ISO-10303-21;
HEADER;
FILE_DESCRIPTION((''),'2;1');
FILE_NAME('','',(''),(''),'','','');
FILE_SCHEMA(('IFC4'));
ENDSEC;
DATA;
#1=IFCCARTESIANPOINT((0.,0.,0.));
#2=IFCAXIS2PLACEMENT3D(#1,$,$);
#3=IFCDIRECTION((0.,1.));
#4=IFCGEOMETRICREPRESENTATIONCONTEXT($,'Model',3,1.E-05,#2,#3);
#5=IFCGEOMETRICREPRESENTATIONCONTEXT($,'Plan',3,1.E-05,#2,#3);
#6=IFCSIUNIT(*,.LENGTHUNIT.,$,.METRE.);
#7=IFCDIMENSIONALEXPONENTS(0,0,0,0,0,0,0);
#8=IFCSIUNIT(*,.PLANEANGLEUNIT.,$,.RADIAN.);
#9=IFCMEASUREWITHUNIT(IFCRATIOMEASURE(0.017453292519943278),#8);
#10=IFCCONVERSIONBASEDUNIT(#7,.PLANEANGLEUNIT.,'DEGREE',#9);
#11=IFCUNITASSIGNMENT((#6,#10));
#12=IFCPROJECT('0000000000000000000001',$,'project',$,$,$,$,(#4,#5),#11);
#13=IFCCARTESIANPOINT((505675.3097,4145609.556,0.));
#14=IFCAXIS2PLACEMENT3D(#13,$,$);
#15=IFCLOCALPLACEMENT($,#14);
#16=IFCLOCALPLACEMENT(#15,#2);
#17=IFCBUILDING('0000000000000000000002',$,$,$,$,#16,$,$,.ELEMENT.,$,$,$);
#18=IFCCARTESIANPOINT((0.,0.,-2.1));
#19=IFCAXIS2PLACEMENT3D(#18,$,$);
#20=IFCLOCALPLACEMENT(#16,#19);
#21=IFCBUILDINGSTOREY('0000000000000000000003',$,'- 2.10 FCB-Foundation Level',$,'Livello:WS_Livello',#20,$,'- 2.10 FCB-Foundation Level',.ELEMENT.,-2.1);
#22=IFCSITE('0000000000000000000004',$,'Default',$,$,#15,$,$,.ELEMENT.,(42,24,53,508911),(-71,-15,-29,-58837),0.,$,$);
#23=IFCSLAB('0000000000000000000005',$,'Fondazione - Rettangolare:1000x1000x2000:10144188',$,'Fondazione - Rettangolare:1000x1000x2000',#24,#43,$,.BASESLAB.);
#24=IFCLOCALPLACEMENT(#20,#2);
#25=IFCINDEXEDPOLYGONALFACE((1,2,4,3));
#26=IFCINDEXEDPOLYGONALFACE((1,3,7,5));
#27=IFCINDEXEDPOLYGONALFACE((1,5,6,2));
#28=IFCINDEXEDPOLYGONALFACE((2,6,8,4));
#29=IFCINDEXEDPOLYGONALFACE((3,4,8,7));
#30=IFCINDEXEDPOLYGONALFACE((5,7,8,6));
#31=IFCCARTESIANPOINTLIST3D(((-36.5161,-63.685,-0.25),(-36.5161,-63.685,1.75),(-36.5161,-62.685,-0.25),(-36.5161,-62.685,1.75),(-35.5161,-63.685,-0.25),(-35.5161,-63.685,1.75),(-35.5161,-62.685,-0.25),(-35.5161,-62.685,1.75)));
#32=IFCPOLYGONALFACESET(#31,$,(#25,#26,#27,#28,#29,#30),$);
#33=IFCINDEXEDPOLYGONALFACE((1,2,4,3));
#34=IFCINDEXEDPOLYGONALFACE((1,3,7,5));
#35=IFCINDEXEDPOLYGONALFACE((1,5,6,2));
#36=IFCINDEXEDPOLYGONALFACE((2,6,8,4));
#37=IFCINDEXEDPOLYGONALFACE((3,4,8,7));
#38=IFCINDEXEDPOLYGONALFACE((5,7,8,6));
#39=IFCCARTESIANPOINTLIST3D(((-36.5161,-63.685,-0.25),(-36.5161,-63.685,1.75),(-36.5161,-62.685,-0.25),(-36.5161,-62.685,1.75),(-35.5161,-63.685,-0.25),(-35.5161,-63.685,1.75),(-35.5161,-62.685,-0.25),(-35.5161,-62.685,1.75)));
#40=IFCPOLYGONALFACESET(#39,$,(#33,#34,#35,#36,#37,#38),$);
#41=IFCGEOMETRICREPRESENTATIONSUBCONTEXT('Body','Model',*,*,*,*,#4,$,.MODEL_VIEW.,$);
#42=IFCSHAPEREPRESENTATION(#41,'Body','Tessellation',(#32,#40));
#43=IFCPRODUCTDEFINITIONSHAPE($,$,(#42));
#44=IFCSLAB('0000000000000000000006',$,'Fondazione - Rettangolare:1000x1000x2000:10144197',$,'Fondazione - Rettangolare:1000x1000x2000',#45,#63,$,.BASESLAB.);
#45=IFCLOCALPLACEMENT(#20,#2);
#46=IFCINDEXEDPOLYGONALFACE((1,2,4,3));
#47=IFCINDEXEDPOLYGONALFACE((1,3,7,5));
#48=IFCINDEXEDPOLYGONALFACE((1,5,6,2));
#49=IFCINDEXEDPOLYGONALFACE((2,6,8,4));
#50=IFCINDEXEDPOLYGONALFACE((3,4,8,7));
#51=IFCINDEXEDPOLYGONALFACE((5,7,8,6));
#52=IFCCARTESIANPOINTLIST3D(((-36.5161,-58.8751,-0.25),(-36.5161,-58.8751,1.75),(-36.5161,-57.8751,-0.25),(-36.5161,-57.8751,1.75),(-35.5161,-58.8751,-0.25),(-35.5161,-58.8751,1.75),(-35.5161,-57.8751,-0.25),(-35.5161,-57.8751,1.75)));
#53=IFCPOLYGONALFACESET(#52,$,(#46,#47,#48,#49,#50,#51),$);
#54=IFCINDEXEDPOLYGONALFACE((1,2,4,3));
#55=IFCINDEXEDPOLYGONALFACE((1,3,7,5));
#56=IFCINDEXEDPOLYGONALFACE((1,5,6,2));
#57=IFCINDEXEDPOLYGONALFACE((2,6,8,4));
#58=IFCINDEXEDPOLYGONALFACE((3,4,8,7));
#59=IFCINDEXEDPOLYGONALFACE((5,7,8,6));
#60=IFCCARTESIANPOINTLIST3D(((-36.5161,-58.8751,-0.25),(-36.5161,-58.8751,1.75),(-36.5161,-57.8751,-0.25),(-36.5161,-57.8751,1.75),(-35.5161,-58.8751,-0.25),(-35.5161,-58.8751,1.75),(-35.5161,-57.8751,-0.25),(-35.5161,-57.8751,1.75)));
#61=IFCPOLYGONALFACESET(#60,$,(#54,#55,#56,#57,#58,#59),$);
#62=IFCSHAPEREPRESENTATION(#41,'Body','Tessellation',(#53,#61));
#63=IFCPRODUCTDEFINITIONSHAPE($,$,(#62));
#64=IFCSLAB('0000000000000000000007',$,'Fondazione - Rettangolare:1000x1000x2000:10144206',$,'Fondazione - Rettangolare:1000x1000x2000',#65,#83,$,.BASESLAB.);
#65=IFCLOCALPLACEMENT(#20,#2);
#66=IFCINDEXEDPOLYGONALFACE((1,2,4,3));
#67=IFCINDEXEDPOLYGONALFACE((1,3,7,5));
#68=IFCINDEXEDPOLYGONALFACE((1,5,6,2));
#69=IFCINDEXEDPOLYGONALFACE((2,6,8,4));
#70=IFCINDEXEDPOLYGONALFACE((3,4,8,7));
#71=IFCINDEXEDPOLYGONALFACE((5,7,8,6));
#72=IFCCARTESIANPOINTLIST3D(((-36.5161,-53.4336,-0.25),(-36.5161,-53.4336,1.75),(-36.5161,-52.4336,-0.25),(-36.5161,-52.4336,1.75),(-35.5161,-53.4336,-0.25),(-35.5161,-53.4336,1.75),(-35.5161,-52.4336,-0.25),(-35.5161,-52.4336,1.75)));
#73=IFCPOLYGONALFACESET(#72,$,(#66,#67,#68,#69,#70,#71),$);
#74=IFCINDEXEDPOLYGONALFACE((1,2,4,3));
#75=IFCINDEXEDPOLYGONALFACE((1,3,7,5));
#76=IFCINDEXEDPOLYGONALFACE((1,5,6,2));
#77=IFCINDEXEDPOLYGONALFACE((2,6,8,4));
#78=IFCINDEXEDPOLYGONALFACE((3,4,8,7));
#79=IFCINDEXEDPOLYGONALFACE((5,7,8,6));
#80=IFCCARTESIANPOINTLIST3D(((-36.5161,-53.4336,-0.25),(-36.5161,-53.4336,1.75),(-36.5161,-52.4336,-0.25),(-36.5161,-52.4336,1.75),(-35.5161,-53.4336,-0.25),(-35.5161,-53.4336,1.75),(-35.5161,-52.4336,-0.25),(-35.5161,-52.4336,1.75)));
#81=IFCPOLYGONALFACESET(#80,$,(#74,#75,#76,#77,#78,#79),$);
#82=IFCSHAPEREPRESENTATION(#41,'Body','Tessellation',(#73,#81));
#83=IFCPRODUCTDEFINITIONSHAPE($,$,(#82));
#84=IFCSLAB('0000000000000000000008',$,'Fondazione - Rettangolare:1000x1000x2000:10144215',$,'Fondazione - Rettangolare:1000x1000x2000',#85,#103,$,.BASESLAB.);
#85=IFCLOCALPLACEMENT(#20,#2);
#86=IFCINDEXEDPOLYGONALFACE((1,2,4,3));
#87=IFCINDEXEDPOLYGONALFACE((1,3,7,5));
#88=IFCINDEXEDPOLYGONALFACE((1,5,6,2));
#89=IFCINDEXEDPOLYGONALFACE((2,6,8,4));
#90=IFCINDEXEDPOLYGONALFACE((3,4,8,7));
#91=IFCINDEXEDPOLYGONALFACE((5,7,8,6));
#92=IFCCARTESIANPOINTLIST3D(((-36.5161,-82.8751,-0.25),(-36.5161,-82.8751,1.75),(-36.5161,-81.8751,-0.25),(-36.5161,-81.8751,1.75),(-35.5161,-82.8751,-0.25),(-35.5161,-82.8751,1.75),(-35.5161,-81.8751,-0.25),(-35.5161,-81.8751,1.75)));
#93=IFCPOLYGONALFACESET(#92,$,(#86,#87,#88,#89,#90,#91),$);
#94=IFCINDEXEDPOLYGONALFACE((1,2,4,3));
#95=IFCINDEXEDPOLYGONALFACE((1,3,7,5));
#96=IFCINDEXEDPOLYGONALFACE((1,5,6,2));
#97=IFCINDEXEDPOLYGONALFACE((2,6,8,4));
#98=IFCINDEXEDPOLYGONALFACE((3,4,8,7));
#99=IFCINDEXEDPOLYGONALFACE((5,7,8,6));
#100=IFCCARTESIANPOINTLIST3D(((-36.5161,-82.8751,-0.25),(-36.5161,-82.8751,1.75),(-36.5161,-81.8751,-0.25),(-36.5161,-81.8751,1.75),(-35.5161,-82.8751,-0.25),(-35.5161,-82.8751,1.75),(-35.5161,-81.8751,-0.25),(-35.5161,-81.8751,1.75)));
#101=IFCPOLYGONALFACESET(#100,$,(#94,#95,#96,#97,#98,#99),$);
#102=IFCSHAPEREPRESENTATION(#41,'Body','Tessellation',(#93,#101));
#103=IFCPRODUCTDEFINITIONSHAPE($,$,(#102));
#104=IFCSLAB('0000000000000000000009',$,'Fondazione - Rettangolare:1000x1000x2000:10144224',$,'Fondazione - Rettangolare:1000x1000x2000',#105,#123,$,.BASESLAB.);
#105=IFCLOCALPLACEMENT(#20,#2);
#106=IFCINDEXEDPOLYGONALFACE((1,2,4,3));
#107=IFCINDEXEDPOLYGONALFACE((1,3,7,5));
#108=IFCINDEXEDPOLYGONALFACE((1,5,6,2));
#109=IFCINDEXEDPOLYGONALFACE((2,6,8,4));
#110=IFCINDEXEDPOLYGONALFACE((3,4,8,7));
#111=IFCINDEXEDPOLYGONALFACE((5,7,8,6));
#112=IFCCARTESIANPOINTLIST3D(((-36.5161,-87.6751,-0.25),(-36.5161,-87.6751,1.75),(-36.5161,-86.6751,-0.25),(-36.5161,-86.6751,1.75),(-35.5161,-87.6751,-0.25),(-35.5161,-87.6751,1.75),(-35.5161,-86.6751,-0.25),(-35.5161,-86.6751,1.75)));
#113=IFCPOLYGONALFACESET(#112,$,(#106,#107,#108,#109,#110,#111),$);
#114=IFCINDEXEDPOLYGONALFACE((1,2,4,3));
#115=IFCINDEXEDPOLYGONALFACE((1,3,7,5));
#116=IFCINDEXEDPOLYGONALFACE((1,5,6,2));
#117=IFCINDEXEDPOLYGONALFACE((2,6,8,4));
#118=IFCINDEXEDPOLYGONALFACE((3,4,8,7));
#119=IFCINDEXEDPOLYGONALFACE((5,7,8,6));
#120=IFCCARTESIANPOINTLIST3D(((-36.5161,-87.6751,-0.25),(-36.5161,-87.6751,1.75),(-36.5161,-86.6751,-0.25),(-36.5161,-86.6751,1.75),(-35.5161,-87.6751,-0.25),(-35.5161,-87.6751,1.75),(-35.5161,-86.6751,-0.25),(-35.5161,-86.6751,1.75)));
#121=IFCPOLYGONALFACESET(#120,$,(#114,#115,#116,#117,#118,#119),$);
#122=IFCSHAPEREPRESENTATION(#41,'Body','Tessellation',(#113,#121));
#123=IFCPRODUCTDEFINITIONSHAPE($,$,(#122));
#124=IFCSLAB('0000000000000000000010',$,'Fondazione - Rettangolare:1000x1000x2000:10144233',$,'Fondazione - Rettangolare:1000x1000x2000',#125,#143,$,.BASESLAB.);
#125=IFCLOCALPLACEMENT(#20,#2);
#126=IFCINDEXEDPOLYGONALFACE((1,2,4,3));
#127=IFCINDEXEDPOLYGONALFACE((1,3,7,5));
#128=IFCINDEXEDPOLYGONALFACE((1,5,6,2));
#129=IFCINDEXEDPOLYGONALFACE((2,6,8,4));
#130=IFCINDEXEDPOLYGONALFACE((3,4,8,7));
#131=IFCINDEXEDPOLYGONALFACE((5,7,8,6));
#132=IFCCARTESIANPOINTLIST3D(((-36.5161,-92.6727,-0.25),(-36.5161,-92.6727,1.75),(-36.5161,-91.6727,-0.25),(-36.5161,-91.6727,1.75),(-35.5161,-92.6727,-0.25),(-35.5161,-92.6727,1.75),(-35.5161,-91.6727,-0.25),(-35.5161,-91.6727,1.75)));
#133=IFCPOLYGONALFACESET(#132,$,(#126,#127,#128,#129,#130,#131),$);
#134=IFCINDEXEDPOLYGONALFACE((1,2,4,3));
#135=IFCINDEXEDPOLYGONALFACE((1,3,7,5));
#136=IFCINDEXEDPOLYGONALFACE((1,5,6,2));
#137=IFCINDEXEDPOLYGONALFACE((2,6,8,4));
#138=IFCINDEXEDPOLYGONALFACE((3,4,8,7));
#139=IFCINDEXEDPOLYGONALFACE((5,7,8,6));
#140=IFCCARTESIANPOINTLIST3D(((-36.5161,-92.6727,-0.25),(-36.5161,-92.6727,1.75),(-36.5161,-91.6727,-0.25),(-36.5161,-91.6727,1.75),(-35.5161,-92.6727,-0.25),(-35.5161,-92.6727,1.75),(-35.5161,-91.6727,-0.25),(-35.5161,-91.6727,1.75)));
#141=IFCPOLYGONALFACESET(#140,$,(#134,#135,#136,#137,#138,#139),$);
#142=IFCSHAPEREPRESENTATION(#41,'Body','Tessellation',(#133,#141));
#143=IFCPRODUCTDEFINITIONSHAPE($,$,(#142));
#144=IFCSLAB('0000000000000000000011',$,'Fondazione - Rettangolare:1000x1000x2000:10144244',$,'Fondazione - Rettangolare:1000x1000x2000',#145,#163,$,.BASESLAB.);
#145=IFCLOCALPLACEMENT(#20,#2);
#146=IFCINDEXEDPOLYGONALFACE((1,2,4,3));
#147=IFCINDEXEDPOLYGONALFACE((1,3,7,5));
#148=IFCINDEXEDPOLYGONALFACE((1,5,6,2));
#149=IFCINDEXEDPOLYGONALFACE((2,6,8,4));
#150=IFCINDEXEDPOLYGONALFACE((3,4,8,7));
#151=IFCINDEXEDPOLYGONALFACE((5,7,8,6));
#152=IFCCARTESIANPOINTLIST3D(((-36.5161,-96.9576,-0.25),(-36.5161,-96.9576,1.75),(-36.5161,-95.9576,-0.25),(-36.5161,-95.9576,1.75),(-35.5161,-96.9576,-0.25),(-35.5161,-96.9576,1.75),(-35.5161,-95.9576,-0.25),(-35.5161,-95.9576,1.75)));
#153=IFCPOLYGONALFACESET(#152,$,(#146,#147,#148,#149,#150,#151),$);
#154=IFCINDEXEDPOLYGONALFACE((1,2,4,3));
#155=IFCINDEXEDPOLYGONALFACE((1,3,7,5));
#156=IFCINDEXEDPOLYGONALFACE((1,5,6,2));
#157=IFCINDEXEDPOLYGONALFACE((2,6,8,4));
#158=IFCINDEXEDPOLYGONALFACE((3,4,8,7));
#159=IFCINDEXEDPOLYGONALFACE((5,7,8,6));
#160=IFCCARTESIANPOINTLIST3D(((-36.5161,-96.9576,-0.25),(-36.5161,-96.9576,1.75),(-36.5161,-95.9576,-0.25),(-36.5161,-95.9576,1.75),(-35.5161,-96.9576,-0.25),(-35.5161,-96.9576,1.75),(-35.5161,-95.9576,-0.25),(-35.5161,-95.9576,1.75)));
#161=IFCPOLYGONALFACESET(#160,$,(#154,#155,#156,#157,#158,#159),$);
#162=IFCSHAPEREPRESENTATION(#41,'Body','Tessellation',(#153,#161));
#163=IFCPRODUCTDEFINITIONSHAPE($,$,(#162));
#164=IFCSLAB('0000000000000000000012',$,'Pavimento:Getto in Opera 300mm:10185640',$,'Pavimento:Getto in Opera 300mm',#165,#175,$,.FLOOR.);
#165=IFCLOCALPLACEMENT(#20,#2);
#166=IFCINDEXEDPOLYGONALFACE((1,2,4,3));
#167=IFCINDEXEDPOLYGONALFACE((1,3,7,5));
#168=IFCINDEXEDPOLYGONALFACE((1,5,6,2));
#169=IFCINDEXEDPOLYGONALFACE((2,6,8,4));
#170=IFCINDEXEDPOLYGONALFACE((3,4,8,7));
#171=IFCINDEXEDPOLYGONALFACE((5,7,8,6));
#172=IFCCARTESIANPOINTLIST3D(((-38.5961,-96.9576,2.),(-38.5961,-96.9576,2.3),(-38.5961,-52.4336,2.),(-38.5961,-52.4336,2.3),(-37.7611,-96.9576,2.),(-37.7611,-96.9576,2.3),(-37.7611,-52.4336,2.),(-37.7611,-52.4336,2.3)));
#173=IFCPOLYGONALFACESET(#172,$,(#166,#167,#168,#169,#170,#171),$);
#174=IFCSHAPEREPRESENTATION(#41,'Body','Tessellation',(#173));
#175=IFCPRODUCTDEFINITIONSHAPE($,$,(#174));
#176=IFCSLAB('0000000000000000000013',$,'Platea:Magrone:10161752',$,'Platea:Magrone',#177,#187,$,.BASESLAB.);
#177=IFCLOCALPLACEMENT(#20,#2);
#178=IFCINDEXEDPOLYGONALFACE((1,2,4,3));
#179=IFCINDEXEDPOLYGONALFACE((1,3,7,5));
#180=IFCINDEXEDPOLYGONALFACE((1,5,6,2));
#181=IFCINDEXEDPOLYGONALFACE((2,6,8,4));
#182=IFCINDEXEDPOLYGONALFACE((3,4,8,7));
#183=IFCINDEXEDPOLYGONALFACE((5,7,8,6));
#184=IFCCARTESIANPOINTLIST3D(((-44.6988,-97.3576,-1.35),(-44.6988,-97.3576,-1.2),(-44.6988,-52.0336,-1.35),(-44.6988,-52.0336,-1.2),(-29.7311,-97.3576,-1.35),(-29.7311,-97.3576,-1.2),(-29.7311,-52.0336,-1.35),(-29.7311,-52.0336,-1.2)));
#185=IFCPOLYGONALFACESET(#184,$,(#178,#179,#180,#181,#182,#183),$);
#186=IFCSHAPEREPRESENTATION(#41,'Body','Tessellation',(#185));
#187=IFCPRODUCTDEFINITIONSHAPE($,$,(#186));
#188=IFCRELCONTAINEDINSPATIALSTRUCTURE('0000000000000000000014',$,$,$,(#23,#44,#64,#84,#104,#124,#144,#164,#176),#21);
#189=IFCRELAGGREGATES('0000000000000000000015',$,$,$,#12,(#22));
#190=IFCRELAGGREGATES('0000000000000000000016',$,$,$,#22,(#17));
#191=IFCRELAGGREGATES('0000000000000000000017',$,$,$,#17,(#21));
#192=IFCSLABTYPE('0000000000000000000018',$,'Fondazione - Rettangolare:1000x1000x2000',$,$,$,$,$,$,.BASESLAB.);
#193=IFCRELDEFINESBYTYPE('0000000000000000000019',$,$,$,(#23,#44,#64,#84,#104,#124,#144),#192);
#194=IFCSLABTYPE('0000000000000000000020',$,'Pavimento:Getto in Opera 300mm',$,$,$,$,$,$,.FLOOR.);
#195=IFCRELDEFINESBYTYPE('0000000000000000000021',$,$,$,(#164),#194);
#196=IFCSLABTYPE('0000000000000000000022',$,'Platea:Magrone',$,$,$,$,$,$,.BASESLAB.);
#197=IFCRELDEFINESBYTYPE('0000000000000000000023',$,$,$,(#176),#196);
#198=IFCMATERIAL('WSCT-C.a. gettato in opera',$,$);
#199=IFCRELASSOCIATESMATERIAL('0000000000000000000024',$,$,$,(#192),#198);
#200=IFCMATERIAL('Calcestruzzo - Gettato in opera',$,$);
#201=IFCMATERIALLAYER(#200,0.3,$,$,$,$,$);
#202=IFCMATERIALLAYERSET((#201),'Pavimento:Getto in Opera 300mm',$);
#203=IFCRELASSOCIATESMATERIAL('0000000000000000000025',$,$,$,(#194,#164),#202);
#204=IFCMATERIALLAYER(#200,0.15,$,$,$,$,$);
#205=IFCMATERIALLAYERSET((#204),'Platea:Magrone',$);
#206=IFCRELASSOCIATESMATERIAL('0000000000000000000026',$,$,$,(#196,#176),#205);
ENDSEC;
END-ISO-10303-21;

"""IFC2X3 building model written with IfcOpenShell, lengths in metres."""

from ifc_helpers import new_model, entity, si_unit, converted_unit, direction, frame, frame_2d, origin, origin_2d_with_axis, place, context, subcontext, project, spatial, rectangle, extrude, material, layer, layer_set, layer_usage, type_object, element, save


model = new_model("IFC2X3")

# Units and contexts
model_context = context("Model", 3, precision=1e-05, world=origin(), true_north=direction((0.0, 1.0)))
plan_context = context("Plan", 3, precision=1e-05, world=origin(), true_north=direction((0.0, 1.0)))
body_context = subcontext(model_context, "Body", "Model", "MODEL_VIEW")
ifc_project = project(units=[si_unit("LENGTHUNIT", "METRE"), converted_unit("PLANEANGLEUNIT", "DEGREE", entity("IfcRatioMeasure", 0.017453292519943278), si_unit("PLANEANGLEUNIT", "RADIAN"), dimensions=[0, 0, 0, 0, 0, 0, 0])], contexts=[model_context, plan_context])

# Site, building, storey
site_placement = place(None, frame((505675.3097, 4145609.556, 0.0)))
site = spatial("IfcSite", under=ifc_project, at=site_placement, Name="Default", CompositionType="ELEMENT", RefLatitude=(42, 24, 53, 508911), RefLongitude=(-71, -15, -29, -58837), RefElevation=0.0)
building_placement = place(site_placement, origin())
building = spatial("IfcBuilding", under=site, at=building_placement, CompositionType="ELEMENT")
storey_placement = place(building_placement, frame((0.0, 0.0, -2.1)))
storey = spatial("IfcBuildingStorey", under=building, at=storey_placement, Name="- 2.10 FCB-Foundation Level", ObjectType="Livello:WS_Livello", LongName="- 2.10 FCB-Foundation Level", CompositionType="ELEMENT", Elevation=-2.1)

# Slabs
ifc_material_1 = material(Name="WSCT-C.a. gettato in opera")
slab_type_1 = type_object("IfcSlabType", Name="Fondazione - Rettangolare:1000x1000x2000", PredefinedType="BASESLAB", material=ifc_material_1)
slab_1_placement = place(storey_placement, origin())
element("IfcSlab", 1, at=slab_1_placement, inside=storey, type_object=slab_type_1, Name="Fondazione - Rettangolare:1000x1000x2000:10144188", ObjectType="Fondazione - Rettangolare:1000x1000x2000", PredefinedType="BASESLAB", context=body_context, shape_type="SweptSolid", body=[
    extrude(rectangle(XDim=1.0, YDim=1.0, at=origin_2d_with_axis()), frame((-36.0161, -63.185, -0.25), z_axis=(0.0, 0.0, 1.0), x_axis=(-1.0, 0.0, 0.0)), (0.0, 0.0, 1.0), 2.0),
    extrude(rectangle(XDim=1.0, YDim=1.0, at=origin_2d_with_axis()), frame((-36.0161, -63.185, -0.25), z_axis=(0.0, 0.0, 1.0), x_axis=(-1.0, 0.0, 0.0)), (0.0, 0.0, 1.0), 2.0),
])
slab_2_placement = place(storey_placement, origin())
element("IfcSlab", 2, at=slab_2_placement, inside=storey, type_object=slab_type_1, Name="Fondazione - Rettangolare:1000x1000x2000:10144197", ObjectType="Fondazione - Rettangolare:1000x1000x2000", PredefinedType="BASESLAB", context=body_context, shape_type="SweptSolid", body=[
    extrude(rectangle(XDim=1.0, YDim=1.0, at=origin_2d_with_axis()), frame((-36.0161, -58.3751, -0.25), z_axis=(0.0, 0.0, 1.0), x_axis=(-1.0, 0.0, 0.0)), (0.0, 0.0, 1.0), 2.0),
    extrude(rectangle(XDim=1.0, YDim=1.0, at=origin_2d_with_axis()), frame((-36.0161, -58.3751, -0.25), z_axis=(0.0, 0.0, 1.0), x_axis=(-1.0, 0.0, 0.0)), (0.0, 0.0, 1.0), 2.0),
])
slab_3_placement = place(storey_placement, origin())
element("IfcSlab", 3, at=slab_3_placement, inside=storey, type_object=slab_type_1, Name="Fondazione - Rettangolare:1000x1000x2000:10144206", ObjectType="Fondazione - Rettangolare:1000x1000x2000", PredefinedType="BASESLAB", context=body_context, shape_type="SweptSolid", body=[
    extrude(rectangle(XDim=1.0, YDim=1.0, at=origin_2d_with_axis()), frame((-36.0161, -52.9336, -0.25), z_axis=(0.0, 0.0, 1.0), x_axis=(-1.0, 0.0, 0.0)), (0.0, 0.0, 1.0), 2.0),
    extrude(rectangle(XDim=1.0, YDim=1.0, at=origin_2d_with_axis()), frame((-36.0161, -52.9336, -0.25), z_axis=(0.0, 0.0, 1.0), x_axis=(-1.0, 0.0, 0.0)), (0.0, 0.0, 1.0), 2.0),
])
slab_4_placement = place(storey_placement, origin())
element("IfcSlab", 4, at=slab_4_placement, inside=storey, type_object=slab_type_1, Name="Fondazione - Rettangolare:1000x1000x2000:10144215", ObjectType="Fondazione - Rettangolare:1000x1000x2000", PredefinedType="BASESLAB", context=body_context, shape_type="SweptSolid", body=[
    extrude(rectangle(XDim=1.0, YDim=1.0, at=frame_2d((0.0, 0.0), x_axis=(1.0, 0.0))), frame((-36.0161, -82.3751, -0.25), z_axis=(0.0, 0.0, 1.0), x_axis=(-1.0, 0.0, 0.0)), (0.0, 0.0, 1.0), 2.0),
    extrude(rectangle(XDim=1.0, YDim=1.0, at=frame_2d((0.0, 0.0), x_axis=(1.0, 0.0))), frame((-36.0161, -82.3751, -0.25), z_axis=(0.0, 0.0, 1.0), x_axis=(-1.0, 0.0, 0.0)), (0.0, 0.0, 1.0), 2.0),
])
slab_5_placement = place(storey_placement, origin())
element("IfcSlab", 5, at=slab_5_placement, inside=storey, type_object=slab_type_1, Name="Fondazione - Rettangolare:1000x1000x2000:10144224", ObjectType="Fondazione - Rettangolare:1000x1000x2000", PredefinedType="BASESLAB", context=body_context, shape_type="SweptSolid", body=[
    extrude(rectangle(XDim=1.0, YDim=1.0, at=frame_2d((0.0, 0.0), x_axis=(1.0, 0.0))), frame((-36.0161, -87.1751, -0.25), z_axis=(0.0, 0.0, 1.0), x_axis=(-1.0, 0.0, 0.0)), (0.0, 0.0, 1.0), 2.0),
    extrude(rectangle(XDim=1.0, YDim=1.0, at=frame_2d((0.0, 0.0), x_axis=(1.0, 0.0))), frame((-36.0161, -87.1751, -0.25), z_axis=(0.0, 0.0, 1.0), x_axis=(-1.0, 0.0, 0.0)), (0.0, 0.0, 1.0), 2.0),
])
slab_6_placement = place(storey_placement, origin())
element("IfcSlab", 6, at=slab_6_placement, inside=storey, type_object=slab_type_1, Name="Fondazione - Rettangolare:1000x1000x2000:10144233", ObjectType="Fondazione - Rettangolare:1000x1000x2000", PredefinedType="BASESLAB", context=body_context, shape_type="SweptSolid", body=[
    extrude(rectangle(XDim=1.0, YDim=1.0, at=frame_2d((0.0, 0.0), x_axis=(1.0, 0.0))), frame((-36.0161, -92.1727, -0.25), z_axis=(0.0, 0.0, 1.0), x_axis=(-1.0, 0.0, 0.0)), (0.0, 0.0, 1.0), 2.0),
    extrude(rectangle(XDim=1.0, YDim=1.0, at=frame_2d((0.0, 0.0), x_axis=(1.0, 0.0))), frame((-36.0161, -92.1727, -0.25), z_axis=(0.0, 0.0, 1.0), x_axis=(-1.0, 0.0, 0.0)), (0.0, 0.0, 1.0), 2.0),
])
slab_7_placement = place(storey_placement, origin())
element("IfcSlab", 7, at=slab_7_placement, inside=storey, type_object=slab_type_1, Name="Fondazione - Rettangolare:1000x1000x2000:10144244", ObjectType="Fondazione - Rettangolare:1000x1000x2000", PredefinedType="BASESLAB", context=body_context, shape_type="SweptSolid", body=[
    extrude(rectangle(XDim=1.0, YDim=1.0, at=frame_2d((0.0, 0.0), x_axis=(1.0, 0.0))), frame((-36.0161, -96.4576, -0.25), z_axis=(0.0, 0.0, 1.0), x_axis=(-1.0, 0.0, 0.0)), (0.0, 0.0, 1.0), 2.0),
    extrude(rectangle(XDim=1.0, YDim=1.0, at=frame_2d((0.0, 0.0), x_axis=(1.0, 0.0))), frame((-36.0161, -96.4576, -0.25), z_axis=(0.0, 0.0, 1.0), x_axis=(-1.0, 0.0, 0.0)), (0.0, 0.0, 1.0), 2.0),
])
ifc_material_2 = material(Name="Calcestruzzo - Gettato in opera")
ifc_layer_1 = layer(ifc_material_2, 0.3)
ifc_layer_set_1 = layer_set([ifc_layer_1], Name="Pavimento:Getto in Opera 300mm")
ifc_layer_usage_1 = layer_usage(ifc_layer_set_1, "AXIS3", "POSITIVE", 0.0)
slab_type_2 = type_object("IfcSlabType", Name="Pavimento:Getto in Opera 300mm", PredefinedType="FLOOR", material=ifc_layer_set_1)
slab_8_placement = place(storey_placement, origin())
element("IfcSlab", 8, at=slab_8_placement, inside=storey, type_object=slab_type_2, material=ifc_layer_usage_1, Name="Pavimento:Getto in Opera 300mm:10185640", ObjectType="Pavimento:Getto in Opera 300mm", PredefinedType="FLOOR", context=body_context, shape_type="SweptSolid", body=[
    extrude(rectangle(XDim=44.524, YDim=0.835, at=frame_2d((0.0, 0.0), x_axis=(1.0, 0.0))), frame((-38.1786, -74.6956, 2.3), z_axis=(0.0, 0.0, -1.0), x_axis=(0.0, 1.0, 0.0)), (0.0, 0.0, 1.0), 0.3),
])
ifc_layer_2 = layer(ifc_material_2, 0.15)
ifc_layer_set_2 = layer_set([ifc_layer_2], Name="Platea:Magrone")
ifc_layer_usage_2 = layer_usage(ifc_layer_set_2, "AXIS3", "POSITIVE", 0.0)
slab_type_3 = type_object("IfcSlabType", Name="Platea:Magrone", PredefinedType="BASESLAB", material=ifc_layer_set_2)
slab_9_placement = place(storey_placement, origin())
element("IfcSlab", 9, at=slab_9_placement, inside=storey, type_object=slab_type_3, material=ifc_layer_usage_2, Name="Platea:Magrone:10161752", ObjectType="Platea:Magrone", PredefinedType="BASESLAB", context=body_context, shape_type="SweptSolid", body=[
    extrude(rectangle(XDim=45.324, YDim=14.9678, at=origin_2d_with_axis()), frame((-37.215, -74.6956, -1.2), z_axis=(0.0, 0.0, -1.0), x_axis=(0.0, 1.0, 0.0)), (0.0, 0.0, 1.0), 0.15),
])

save(model, "model.ifc")
